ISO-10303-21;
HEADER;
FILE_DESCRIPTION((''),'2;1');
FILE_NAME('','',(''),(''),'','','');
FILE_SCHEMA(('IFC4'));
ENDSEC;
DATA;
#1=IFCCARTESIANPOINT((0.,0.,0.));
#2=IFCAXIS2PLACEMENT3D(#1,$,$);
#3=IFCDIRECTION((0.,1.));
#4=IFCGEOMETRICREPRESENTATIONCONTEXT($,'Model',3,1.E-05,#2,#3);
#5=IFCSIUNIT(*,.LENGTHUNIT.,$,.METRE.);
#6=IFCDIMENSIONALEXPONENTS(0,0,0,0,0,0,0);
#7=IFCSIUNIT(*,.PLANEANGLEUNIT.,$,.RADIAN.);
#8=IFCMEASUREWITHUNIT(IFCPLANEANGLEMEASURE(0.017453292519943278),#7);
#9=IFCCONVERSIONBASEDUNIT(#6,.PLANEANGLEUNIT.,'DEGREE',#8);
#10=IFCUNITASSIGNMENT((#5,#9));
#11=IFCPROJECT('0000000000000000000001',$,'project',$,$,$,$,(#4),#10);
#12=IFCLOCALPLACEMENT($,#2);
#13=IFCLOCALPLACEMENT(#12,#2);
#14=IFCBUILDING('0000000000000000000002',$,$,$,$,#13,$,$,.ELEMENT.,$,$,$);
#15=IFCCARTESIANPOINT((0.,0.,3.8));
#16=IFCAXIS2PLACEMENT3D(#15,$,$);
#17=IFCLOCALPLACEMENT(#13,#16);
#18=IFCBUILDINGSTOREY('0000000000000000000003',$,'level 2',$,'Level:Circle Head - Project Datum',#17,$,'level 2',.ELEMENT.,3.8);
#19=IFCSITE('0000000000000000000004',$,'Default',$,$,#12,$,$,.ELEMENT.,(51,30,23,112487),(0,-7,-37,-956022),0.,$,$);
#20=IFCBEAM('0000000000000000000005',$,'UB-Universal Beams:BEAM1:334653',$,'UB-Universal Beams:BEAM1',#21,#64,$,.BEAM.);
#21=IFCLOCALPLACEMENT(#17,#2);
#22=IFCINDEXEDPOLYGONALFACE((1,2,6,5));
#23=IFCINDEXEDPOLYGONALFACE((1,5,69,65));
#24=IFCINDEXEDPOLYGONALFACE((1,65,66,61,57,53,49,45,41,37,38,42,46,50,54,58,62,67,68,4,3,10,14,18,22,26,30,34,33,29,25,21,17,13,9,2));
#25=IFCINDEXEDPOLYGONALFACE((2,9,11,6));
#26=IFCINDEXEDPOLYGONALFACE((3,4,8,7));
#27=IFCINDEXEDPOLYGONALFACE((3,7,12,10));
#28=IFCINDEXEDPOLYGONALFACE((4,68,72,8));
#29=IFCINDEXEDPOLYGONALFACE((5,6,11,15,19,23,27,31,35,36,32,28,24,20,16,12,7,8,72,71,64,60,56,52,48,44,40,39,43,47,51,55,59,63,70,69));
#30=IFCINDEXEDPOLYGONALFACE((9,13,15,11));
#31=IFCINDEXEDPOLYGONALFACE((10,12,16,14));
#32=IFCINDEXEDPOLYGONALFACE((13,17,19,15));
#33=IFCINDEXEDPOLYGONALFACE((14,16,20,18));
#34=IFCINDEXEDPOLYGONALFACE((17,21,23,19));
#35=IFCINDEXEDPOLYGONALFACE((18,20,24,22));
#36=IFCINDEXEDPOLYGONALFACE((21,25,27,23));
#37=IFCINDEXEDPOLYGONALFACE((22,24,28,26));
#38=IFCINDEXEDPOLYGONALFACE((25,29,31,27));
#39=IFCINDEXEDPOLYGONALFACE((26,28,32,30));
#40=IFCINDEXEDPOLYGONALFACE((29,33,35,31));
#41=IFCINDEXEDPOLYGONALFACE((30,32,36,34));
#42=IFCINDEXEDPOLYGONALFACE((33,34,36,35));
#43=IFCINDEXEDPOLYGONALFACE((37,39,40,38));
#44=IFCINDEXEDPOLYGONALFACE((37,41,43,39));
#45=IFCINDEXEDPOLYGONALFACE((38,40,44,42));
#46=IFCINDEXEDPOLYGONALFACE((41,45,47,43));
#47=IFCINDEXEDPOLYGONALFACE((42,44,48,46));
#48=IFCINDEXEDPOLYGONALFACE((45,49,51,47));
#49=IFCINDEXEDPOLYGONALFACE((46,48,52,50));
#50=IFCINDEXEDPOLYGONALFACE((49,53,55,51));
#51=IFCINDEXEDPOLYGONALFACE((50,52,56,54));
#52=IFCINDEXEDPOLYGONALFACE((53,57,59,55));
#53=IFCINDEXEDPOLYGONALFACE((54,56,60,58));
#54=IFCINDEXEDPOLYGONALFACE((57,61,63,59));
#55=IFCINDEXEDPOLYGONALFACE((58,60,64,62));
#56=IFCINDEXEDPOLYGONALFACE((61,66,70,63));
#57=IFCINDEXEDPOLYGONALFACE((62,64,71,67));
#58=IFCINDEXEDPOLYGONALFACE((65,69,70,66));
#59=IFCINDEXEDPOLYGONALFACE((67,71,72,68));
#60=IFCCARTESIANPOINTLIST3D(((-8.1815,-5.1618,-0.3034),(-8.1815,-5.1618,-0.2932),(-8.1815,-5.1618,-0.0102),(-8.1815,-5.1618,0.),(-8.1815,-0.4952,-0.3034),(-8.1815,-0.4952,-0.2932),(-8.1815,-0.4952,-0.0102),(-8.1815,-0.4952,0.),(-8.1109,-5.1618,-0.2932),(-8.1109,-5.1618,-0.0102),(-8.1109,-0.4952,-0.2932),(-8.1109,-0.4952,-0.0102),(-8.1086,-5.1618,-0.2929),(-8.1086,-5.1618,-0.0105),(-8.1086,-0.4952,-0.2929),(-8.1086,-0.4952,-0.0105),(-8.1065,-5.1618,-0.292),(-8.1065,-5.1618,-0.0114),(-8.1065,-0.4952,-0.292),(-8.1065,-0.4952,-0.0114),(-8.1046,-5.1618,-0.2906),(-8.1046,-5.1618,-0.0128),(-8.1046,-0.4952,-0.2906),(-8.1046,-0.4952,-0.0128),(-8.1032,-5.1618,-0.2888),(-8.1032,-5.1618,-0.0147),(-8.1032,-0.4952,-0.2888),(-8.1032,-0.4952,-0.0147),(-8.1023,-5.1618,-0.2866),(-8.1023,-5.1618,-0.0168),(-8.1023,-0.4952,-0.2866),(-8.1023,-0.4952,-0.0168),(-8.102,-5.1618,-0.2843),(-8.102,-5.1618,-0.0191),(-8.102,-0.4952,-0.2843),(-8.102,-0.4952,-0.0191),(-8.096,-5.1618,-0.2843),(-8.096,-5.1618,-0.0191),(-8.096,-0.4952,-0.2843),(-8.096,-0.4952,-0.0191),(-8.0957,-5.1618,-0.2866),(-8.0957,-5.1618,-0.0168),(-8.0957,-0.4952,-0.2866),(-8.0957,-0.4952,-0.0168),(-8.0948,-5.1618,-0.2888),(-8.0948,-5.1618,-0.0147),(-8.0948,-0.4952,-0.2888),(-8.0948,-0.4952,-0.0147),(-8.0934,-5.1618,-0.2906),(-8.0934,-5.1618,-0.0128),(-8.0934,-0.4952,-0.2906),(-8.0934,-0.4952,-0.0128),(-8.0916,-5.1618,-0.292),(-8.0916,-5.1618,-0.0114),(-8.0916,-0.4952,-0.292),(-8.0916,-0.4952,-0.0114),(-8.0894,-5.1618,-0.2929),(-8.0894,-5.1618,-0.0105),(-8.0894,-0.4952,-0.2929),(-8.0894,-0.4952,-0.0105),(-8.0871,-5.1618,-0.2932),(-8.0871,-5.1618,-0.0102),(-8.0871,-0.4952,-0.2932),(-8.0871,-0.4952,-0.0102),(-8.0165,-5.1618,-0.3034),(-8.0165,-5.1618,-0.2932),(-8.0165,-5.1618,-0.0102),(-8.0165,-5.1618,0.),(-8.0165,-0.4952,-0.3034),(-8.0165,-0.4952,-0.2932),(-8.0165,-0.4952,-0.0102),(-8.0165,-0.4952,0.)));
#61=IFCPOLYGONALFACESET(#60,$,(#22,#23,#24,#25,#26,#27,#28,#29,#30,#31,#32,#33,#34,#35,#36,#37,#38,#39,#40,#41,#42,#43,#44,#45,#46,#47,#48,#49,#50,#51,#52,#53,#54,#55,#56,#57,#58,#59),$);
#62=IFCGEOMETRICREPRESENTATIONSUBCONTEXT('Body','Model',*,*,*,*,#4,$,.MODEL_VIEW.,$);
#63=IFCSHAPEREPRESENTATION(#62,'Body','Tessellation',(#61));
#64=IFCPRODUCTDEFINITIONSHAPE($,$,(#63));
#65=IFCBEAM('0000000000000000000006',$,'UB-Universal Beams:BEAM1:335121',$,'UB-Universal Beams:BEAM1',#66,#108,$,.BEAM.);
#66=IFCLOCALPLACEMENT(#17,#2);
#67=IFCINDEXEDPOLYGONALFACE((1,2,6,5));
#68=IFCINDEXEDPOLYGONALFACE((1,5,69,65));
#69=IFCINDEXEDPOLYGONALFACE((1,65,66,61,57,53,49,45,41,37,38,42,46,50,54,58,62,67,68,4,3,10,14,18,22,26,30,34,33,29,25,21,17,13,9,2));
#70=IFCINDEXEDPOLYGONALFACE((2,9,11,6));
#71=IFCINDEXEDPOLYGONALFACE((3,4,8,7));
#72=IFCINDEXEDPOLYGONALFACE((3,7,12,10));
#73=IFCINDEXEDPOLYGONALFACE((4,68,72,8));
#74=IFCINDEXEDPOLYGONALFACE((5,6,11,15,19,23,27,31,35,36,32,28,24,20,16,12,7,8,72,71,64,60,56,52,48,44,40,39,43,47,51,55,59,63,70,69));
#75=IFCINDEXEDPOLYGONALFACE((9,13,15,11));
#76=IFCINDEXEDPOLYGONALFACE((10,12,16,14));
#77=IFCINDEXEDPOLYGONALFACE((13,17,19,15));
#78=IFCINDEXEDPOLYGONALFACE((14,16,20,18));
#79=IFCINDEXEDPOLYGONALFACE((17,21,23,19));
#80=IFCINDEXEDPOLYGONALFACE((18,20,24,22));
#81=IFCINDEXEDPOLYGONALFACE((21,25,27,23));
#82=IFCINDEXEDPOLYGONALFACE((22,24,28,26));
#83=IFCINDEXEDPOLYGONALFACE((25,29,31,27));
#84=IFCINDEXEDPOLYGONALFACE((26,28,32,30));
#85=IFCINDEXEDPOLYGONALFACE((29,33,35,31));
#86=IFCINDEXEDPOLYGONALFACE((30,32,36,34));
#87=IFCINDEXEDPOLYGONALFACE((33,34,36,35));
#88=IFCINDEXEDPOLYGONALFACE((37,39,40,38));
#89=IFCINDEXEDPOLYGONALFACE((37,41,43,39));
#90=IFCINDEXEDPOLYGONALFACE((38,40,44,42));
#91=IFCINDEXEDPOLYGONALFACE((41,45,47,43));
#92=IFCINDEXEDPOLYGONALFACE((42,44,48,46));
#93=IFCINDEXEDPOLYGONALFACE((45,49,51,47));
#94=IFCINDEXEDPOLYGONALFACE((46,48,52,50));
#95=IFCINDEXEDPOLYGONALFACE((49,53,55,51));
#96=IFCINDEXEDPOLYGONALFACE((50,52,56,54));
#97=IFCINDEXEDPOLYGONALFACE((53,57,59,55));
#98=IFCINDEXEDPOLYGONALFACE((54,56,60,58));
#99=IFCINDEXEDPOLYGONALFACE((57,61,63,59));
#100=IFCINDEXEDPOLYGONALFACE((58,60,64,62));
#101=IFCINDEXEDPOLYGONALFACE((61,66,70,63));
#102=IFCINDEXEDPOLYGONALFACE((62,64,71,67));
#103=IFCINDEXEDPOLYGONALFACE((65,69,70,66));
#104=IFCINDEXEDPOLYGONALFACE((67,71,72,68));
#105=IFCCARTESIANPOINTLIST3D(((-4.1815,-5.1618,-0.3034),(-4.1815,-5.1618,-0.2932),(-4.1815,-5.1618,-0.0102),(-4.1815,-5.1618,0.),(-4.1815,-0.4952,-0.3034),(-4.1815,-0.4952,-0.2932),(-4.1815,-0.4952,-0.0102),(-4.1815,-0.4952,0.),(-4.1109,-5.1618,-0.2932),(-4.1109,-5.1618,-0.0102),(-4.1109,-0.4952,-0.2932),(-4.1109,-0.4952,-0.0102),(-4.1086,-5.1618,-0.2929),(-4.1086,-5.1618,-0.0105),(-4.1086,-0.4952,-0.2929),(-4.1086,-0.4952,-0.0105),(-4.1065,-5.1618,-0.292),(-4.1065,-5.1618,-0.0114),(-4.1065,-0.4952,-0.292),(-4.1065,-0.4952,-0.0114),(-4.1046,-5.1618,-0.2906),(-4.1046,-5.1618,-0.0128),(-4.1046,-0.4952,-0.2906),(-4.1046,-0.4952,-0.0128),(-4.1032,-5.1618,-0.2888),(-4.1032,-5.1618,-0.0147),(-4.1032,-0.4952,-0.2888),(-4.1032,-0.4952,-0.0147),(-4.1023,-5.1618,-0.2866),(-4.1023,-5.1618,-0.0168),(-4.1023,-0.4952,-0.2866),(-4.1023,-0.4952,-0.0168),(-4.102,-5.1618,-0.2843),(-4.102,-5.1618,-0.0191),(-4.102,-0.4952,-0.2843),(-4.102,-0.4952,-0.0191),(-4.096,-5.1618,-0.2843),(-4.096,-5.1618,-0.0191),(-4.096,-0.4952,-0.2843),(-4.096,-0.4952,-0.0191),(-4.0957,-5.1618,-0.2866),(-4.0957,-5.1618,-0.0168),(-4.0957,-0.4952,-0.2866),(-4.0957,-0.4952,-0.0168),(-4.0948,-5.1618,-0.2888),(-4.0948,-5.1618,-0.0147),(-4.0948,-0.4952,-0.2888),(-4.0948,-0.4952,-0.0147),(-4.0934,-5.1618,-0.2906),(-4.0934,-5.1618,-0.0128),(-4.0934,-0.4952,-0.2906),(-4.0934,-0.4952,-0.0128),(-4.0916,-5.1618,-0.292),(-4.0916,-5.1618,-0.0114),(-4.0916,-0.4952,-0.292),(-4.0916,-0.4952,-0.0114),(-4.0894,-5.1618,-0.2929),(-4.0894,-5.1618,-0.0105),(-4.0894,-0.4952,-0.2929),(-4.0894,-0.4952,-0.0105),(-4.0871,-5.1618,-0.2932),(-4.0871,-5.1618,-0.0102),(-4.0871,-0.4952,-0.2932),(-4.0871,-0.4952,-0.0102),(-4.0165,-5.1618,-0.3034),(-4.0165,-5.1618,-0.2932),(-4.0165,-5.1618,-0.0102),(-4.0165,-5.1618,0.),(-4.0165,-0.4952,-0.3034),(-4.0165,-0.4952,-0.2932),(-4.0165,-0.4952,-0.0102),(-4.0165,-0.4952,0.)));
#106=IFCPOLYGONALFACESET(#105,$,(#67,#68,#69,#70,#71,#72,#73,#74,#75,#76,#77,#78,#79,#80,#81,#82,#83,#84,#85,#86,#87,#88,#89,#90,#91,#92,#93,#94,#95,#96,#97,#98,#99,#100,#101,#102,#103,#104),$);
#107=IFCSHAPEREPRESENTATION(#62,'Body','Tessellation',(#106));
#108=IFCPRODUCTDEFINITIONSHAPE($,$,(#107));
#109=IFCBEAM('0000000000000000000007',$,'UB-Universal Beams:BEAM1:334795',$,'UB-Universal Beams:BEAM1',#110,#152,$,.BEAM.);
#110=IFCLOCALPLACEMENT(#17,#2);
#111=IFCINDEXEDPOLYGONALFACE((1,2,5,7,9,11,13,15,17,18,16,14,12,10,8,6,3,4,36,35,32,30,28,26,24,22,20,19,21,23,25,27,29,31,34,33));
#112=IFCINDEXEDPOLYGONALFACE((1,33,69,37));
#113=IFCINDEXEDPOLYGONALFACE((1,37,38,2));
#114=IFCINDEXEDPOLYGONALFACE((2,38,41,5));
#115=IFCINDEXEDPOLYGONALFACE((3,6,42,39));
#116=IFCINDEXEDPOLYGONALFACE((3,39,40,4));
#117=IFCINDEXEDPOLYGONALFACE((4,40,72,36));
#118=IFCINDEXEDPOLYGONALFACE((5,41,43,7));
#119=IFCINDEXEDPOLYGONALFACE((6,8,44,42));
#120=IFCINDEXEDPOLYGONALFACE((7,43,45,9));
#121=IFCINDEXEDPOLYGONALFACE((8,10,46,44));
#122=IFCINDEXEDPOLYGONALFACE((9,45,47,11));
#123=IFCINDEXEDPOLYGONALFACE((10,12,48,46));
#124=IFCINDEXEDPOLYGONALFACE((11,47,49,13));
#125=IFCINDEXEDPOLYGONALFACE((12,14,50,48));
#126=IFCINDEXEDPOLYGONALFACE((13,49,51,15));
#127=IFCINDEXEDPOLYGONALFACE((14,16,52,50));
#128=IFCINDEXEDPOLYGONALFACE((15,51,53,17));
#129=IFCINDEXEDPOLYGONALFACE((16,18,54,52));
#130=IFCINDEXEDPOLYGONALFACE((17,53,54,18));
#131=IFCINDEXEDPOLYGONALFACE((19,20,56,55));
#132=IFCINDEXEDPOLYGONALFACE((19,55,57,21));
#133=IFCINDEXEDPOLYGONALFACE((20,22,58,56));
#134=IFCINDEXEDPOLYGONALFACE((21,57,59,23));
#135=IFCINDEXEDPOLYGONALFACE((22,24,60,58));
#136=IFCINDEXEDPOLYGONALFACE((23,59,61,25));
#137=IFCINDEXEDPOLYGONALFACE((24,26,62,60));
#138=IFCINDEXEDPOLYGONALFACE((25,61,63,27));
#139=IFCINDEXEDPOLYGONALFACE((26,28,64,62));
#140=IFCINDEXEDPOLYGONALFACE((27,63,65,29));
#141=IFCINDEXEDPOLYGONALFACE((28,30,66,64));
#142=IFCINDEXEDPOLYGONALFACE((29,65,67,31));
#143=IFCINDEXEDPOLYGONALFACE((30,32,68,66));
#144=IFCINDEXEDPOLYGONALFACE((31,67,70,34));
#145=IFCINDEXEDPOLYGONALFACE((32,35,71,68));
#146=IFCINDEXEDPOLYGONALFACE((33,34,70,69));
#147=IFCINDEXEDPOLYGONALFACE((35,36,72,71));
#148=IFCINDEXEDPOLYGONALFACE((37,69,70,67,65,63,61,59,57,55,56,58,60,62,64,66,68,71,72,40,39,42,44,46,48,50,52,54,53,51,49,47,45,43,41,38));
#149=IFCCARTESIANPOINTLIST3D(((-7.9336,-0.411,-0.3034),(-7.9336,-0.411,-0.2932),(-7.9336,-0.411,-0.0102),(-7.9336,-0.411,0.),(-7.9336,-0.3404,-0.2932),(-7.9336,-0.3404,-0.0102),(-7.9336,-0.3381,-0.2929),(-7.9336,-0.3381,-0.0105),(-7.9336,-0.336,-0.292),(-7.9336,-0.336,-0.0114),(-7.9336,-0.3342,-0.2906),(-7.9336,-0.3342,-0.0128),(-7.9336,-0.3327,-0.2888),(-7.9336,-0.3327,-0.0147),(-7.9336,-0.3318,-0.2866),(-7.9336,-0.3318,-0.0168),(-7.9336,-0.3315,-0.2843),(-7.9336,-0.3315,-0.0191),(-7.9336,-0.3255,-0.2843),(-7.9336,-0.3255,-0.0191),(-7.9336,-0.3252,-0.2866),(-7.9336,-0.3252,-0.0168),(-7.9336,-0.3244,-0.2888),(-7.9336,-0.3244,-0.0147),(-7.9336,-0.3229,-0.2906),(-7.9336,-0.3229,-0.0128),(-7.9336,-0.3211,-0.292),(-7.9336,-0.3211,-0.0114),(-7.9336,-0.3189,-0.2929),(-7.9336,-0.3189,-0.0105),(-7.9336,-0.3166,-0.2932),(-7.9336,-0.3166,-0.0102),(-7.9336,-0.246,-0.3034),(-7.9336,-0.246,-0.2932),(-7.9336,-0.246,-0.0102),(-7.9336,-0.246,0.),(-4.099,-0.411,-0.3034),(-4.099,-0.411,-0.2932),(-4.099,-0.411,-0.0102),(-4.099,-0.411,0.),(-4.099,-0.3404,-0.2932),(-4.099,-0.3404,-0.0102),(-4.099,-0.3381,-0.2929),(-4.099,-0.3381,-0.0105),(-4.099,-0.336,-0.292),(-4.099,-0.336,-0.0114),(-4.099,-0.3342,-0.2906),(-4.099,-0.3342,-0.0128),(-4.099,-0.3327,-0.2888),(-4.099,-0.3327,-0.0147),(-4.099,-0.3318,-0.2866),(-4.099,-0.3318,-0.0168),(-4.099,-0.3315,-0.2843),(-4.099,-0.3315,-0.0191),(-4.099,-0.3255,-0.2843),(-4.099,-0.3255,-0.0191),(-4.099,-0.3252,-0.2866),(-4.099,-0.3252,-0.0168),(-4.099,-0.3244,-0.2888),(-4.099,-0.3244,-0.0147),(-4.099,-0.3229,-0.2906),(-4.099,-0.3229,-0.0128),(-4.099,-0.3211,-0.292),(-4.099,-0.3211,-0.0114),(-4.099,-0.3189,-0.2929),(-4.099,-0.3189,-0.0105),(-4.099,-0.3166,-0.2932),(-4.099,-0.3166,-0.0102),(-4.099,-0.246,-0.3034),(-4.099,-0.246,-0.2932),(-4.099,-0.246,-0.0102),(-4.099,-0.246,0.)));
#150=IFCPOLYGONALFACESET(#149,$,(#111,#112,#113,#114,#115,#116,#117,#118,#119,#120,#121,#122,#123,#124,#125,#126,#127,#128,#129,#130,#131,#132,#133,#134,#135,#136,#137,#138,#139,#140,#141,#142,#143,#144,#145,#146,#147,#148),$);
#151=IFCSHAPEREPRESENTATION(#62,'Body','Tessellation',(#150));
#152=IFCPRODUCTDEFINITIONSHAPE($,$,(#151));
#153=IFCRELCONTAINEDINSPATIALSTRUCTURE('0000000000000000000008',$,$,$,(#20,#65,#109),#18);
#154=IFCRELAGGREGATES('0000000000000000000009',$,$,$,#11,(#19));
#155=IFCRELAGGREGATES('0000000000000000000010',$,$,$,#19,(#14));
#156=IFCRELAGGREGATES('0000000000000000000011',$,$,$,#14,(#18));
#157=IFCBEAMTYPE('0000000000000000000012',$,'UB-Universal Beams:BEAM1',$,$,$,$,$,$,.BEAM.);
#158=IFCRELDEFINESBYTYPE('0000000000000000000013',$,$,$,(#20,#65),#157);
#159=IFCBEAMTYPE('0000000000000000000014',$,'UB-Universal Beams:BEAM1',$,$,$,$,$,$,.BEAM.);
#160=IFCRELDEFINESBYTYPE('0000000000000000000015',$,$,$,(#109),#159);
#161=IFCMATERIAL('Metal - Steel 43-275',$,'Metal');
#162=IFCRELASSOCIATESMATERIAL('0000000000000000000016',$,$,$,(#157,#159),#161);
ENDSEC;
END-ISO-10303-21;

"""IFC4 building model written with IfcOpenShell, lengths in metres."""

from ifc_helpers import new_model, entity, si_unit, converted_unit, direction, frame, frame_2d, origin, place, context, subcontext, project, spatial, polyline, circle_curve, parameter, trimmed, segment, composite_curve, outline, extrude, source, transform, mapped, material, material_profile, profile_set, type_object, type_shapes, element, save


model = new_model("IFC4")

# Units and contexts
model_context = context("Model", 3, precision=1e-05, world=origin(), true_north=direction((0.0, 1.0)))
body_context = subcontext(model_context, "Body", "Model", "MODEL_VIEW")
ifc_project = project(units=[si_unit("LENGTHUNIT", "METRE"), converted_unit("PLANEANGLEUNIT", "DEGREE", entity("IfcPlaneAngleMeasure", 0.017453292519943278), si_unit("PLANEANGLEUNIT", "RADIAN"), dimensions=[0, 0, 0, 0, 0, 0, 0])], contexts=[model_context])

# Site, building, storey
site_placement = place(None, origin())
site = spatial("IfcSite", under=ifc_project, at=site_placement, Name="Default", CompositionType="ELEMENT", RefLatitude=(51, 30, 23, 112487), RefLongitude=(0, -7, -37, -956022), RefElevation=0.0)
building_placement = place(site_placement, origin())
building = spatial("IfcBuilding", under=site, at=building_placement, CompositionType="ELEMENT")
storey_placement = place(building_placement, frame((0.0, 0.0, 3.8)))
storey = spatial("IfcBuildingStorey", under=building, at=storey_placement, Name="level 2", ObjectType="Level:Circle Head - Project Datum", LongName="level 2", CompositionType="ELEMENT", Elevation=3.8)

# Shared definitions
ifc_material_1 = material(Name="Metal - Steel 43-275", Category="Metal")

# Beams
ifc_material_profile_1 = material_profile(ifc_material_1, outline(composite_curve([segment(polyline([(-0.0825, -0.1415), (-0.0825, -0.1517)]), True, "CONTINUOUS"), segment(polyline([(-0.0825, -0.1517), (0.0825, -0.1517)]), True, "CONTINUOUS"), segment(polyline([(0.0825, -0.1517), (0.0825, -0.1415)]), True, "CONTINUOUS"), segment(polyline([(0.0825, -0.1415), (0.0119, -0.1415)]), True, "CONTINUOUS"), segment(trimmed(circle_curve(frame_2d((0.0119, -0.1326), x_axis=(1.0, 0.0)), 0.0089), [parameter(180.0)], [parameter(270.0)], True, "PARAMETER"), False, "CONTINUOUS"), segment(polyline([(0.003, -0.1326), (0.003, 0.1326)]), True, "CONTINUOUS"), segment(trimmed(circle_curve(frame_2d((0.0119, 0.1326), x_axis=(1.0, 0.0)), 0.0089), [parameter(90.0)], [parameter(180.0)], True, "PARAMETER"), False, "CONTINUOUS"), segment(polyline([(0.0119, 0.1415), (0.0825, 0.1415)]), True, "CONTINUOUS"), segment(polyline([(0.0825, 0.1415), (0.0825, 0.1517)]), True, "CONTINUOUS"), segment(polyline([(0.0825, 0.1517), (-0.0825, 0.1517)]), True, "CONTINUOUS"), segment(polyline([(-0.0825, 0.1517), (-0.0825, 0.1415)]), True, "CONTINUOUS"), segment(polyline([(-0.0825, 0.1415), (-0.0119, 0.1415)]), True, "CONTINUOUS"), segment(trimmed(circle_curve(frame_2d((-0.0119, 0.1326), x_axis=(1.0, 0.0)), 0.0089), [parameter(360.0)], [parameter(90.0)], True, "PARAMETER"), False, "CONTINUOUS"), segment(polyline([(-0.003, 0.1326), (-0.003, -0.1326)]), True, "CONTINUOUS"), segment(trimmed(circle_curve(frame_2d((-0.0119, -0.1326), x_axis=(1.0, 0.0)), 0.0089), [parameter(270.0)], [parameter(360.0)], True, "PARAMETER"), False, "CONTINUOUS"), segment(polyline([(-0.0119, -0.1415), (-0.0825, -0.1415)]), True, "CONTINUOUS")], self_intersect=False)), Name="BEAM1")
ifc_profile_set_1 = profile_set([ifc_material_profile_1], Name="BEAM1")
beam_type_1 = type_object("IfcBeamType", Name="UB-Universal Beams:BEAM1", PredefinedType="BEAM", material=ifc_profile_set_1)
shared_shape_1 = source(origin(), body_context, "Body", "SweptSolid", [
    extrude(outline(composite_curve([segment(polyline([(-0.0825, -0.1415), (-0.0825, -0.1517)]), True, "CONTINUOUS"), segment(polyline([(-0.0825, -0.1517), (0.0825, -0.1517)]), True, "CONTINUOUS"), segment(polyline([(0.0825, -0.1517), (0.0825, -0.1415)]), True, "CONTINUOUS"), segment(polyline([(0.0825, -0.1415), (0.0119, -0.1415)]), True, "CONTINUOUS"), segment(trimmed(circle_curve(frame_2d((0.0119, -0.1326), x_axis=(0.0, -1.0)), 0.0089), [parameter(270.0)], [parameter(360.0)], True, "PARAMETER"), False, "CONTINUOUS"), segment(polyline([(0.003, -0.1326), (0.003, 0.1326)]), True, "CONTINUOUS"), segment(trimmed(circle_curve(frame_2d((0.0119, 0.1326), x_axis=(-1.0, 0.0)), 0.0089), [parameter(270.0)], [parameter(360.0)], True, "PARAMETER"), False, "CONTINUOUS"), segment(polyline([(0.0119, 0.1415), (0.0825, 0.1415)]), True, "CONTINUOUS"), segment(polyline([(0.0825, 0.1415), (0.0825, 0.1517)]), True, "CONTINUOUS"), segment(polyline([(0.0825, 0.1517), (-0.0825, 0.1517)]), True, "CONTINUOUS"), segment(polyline([(-0.0825, 0.1517), (-0.0825, 0.1415)]), True, "CONTINUOUS"), segment(polyline([(-0.0825, 0.1415), (-0.0119, 0.1415)]), True, "CONTINUOUS"), segment(trimmed(circle_curve(frame_2d((-0.0119, 0.1326), x_axis=(0.0, 1.0)), 0.0089), [parameter(270.0)], [parameter(360.0)], True, "PARAMETER"), False, "CONTINUOUS"), segment(polyline([(-0.003, 0.1326), (-0.003, -0.1326)]), True, "CONTINUOUS"), segment(trimmed(circle_curve(frame_2d((-0.0119, -0.1326), x_axis=(1.0, 0.0)), 0.0089), [parameter(270.0)], [parameter(0.0)], True, "PARAMETER"), False, "CONTINUOUS"), segment(polyline([(-0.0119, -0.1415), (-0.0825, -0.1415)]), True, "CONTINUOUS")], self_intersect=False)), frame((-2.3333, 0.0, 0.0), z_axis=(-1.0, 0.0, 0.0), x_axis=(0.0, -1.0, 0.0)), (0.0, 0.0, -1.0), 4.6666),
])
type_shapes(beam_type_1, [shared_shape_1])
for number, where, z_axis, x_axis, name in (
    (1, (-8.099, -2.8285, -0.1517), (0.0, 0.0, 1.0), (0.0, 1.0, 0.0), "UB-Universal Beams:BEAM1:334653"),
    (2, (-4.099, -2.8285, -0.1517), (0.0, 0.0, 1.0), (0.0, 1.0, 0.0), "UB-Universal Beams:BEAM1:335121"),
):
    element("IfcBeam", number, at=place(storey_placement, frame(where, z_axis=z_axis, x_axis=x_axis)), inside=storey, type_object=beam_type_1, Name=name, ObjectType="UB-Universal Beams:BEAM1", PredefinedType="BEAM", context=body_context, shape_type="MappedRepresentation", body=[
        mapped(shared_shape_1, transform((0.0, 0.0, 0.0), scale=1.0)),
    ])
beam_type_2 = type_object("IfcBeamType", Name="UB-Universal Beams:BEAM1", PredefinedType="BEAM", material=ifc_profile_set_1)
shared_shape_2 = source(origin(), body_context, "Body", "SweptSolid", [
    extrude(outline(composite_curve([segment(polyline([(-0.0825, -0.1415), (-0.0825, -0.1517)]), True, "CONTINUOUS"), segment(polyline([(-0.0825, -0.1517), (0.0825, -0.1517)]), True, "CONTINUOUS"), segment(polyline([(0.0825, -0.1517), (0.0825, -0.1415)]), True, "CONTINUOUS"), segment(polyline([(0.0825, -0.1415), (0.0119, -0.1415)]), True, "CONTINUOUS"), segment(trimmed(circle_curve(frame_2d((0.0119, -0.1326), x_axis=(1.0, 0.0)), 0.0089), [parameter(180.0)], [parameter(270.0)], True, "PARAMETER"), False, "CONTINUOUS"), segment(polyline([(0.003, -0.1326), (0.003, 0.1326)]), True, "CONTINUOUS"), segment(trimmed(circle_curve(frame_2d((0.0119, 0.1326), x_axis=(1.0, 0.0)), 0.0089), [parameter(90.0)], [parameter(180.0)], True, "PARAMETER"), False, "CONTINUOUS"), segment(polyline([(0.0119, 0.1415), (0.0825, 0.1415)]), True, "CONTINUOUS"), segment(polyline([(0.0825, 0.1415), (0.0825, 0.1517)]), True, "CONTINUOUS"), segment(polyline([(0.0825, 0.1517), (-0.0825, 0.1517)]), True, "CONTINUOUS"), segment(polyline([(-0.0825, 0.1517), (-0.0825, 0.1415)]), True, "CONTINUOUS"), segment(polyline([(-0.0825, 0.1415), (-0.0119, 0.1415)]), True, "CONTINUOUS"), segment(trimmed(circle_curve(frame_2d((-0.0119, 0.1326), x_axis=(1.0, 0.0)), 0.0089), [parameter(360.0)], [parameter(90.0)], True, "PARAMETER"), False, "CONTINUOUS"), segment(polyline([(-0.003, 0.1326), (-0.003, -0.1326)]), True, "CONTINUOUS"), segment(trimmed(circle_curve(frame_2d((-0.0119, -0.1326), x_axis=(1.0, 0.0)), 0.0089), [parameter(270.0)], [parameter(360.0)], True, "PARAMETER"), False, "CONTINUOUS"), segment(polyline([(-0.0119, -0.1415), (-0.0825, -0.1415)]), True, "CONTINUOUS")], self_intersect=False)), frame((-2.0, 0.0, 0.0), z_axis=(-1.0, 0.0, 0.0), x_axis=(0.0, -1.0, 0.0)), (0.0, 0.0, -1.0), 3.8346),
])
type_shapes(beam_type_2, [shared_shape_2])
beam_1_placement = place(storey_placement, frame((-6.099, -0.3285, -0.1517), z_axis=(0.0, 0.0, 1.0), x_axis=(-1.0, 0.0, 0.0)))
element("IfcBeam", 3, at=beam_1_placement, inside=storey, type_object=beam_type_2, Name="UB-Universal Beams:BEAM1:334795", ObjectType="UB-Universal Beams:BEAM1", PredefinedType="BEAM", context=body_context, shape_type="MappedRepresentation", body=[
    mapped(shared_shape_2, transform((0.0, 0.0, 0.0), scale=1.0)),
])

save(model, "model.ifc")
